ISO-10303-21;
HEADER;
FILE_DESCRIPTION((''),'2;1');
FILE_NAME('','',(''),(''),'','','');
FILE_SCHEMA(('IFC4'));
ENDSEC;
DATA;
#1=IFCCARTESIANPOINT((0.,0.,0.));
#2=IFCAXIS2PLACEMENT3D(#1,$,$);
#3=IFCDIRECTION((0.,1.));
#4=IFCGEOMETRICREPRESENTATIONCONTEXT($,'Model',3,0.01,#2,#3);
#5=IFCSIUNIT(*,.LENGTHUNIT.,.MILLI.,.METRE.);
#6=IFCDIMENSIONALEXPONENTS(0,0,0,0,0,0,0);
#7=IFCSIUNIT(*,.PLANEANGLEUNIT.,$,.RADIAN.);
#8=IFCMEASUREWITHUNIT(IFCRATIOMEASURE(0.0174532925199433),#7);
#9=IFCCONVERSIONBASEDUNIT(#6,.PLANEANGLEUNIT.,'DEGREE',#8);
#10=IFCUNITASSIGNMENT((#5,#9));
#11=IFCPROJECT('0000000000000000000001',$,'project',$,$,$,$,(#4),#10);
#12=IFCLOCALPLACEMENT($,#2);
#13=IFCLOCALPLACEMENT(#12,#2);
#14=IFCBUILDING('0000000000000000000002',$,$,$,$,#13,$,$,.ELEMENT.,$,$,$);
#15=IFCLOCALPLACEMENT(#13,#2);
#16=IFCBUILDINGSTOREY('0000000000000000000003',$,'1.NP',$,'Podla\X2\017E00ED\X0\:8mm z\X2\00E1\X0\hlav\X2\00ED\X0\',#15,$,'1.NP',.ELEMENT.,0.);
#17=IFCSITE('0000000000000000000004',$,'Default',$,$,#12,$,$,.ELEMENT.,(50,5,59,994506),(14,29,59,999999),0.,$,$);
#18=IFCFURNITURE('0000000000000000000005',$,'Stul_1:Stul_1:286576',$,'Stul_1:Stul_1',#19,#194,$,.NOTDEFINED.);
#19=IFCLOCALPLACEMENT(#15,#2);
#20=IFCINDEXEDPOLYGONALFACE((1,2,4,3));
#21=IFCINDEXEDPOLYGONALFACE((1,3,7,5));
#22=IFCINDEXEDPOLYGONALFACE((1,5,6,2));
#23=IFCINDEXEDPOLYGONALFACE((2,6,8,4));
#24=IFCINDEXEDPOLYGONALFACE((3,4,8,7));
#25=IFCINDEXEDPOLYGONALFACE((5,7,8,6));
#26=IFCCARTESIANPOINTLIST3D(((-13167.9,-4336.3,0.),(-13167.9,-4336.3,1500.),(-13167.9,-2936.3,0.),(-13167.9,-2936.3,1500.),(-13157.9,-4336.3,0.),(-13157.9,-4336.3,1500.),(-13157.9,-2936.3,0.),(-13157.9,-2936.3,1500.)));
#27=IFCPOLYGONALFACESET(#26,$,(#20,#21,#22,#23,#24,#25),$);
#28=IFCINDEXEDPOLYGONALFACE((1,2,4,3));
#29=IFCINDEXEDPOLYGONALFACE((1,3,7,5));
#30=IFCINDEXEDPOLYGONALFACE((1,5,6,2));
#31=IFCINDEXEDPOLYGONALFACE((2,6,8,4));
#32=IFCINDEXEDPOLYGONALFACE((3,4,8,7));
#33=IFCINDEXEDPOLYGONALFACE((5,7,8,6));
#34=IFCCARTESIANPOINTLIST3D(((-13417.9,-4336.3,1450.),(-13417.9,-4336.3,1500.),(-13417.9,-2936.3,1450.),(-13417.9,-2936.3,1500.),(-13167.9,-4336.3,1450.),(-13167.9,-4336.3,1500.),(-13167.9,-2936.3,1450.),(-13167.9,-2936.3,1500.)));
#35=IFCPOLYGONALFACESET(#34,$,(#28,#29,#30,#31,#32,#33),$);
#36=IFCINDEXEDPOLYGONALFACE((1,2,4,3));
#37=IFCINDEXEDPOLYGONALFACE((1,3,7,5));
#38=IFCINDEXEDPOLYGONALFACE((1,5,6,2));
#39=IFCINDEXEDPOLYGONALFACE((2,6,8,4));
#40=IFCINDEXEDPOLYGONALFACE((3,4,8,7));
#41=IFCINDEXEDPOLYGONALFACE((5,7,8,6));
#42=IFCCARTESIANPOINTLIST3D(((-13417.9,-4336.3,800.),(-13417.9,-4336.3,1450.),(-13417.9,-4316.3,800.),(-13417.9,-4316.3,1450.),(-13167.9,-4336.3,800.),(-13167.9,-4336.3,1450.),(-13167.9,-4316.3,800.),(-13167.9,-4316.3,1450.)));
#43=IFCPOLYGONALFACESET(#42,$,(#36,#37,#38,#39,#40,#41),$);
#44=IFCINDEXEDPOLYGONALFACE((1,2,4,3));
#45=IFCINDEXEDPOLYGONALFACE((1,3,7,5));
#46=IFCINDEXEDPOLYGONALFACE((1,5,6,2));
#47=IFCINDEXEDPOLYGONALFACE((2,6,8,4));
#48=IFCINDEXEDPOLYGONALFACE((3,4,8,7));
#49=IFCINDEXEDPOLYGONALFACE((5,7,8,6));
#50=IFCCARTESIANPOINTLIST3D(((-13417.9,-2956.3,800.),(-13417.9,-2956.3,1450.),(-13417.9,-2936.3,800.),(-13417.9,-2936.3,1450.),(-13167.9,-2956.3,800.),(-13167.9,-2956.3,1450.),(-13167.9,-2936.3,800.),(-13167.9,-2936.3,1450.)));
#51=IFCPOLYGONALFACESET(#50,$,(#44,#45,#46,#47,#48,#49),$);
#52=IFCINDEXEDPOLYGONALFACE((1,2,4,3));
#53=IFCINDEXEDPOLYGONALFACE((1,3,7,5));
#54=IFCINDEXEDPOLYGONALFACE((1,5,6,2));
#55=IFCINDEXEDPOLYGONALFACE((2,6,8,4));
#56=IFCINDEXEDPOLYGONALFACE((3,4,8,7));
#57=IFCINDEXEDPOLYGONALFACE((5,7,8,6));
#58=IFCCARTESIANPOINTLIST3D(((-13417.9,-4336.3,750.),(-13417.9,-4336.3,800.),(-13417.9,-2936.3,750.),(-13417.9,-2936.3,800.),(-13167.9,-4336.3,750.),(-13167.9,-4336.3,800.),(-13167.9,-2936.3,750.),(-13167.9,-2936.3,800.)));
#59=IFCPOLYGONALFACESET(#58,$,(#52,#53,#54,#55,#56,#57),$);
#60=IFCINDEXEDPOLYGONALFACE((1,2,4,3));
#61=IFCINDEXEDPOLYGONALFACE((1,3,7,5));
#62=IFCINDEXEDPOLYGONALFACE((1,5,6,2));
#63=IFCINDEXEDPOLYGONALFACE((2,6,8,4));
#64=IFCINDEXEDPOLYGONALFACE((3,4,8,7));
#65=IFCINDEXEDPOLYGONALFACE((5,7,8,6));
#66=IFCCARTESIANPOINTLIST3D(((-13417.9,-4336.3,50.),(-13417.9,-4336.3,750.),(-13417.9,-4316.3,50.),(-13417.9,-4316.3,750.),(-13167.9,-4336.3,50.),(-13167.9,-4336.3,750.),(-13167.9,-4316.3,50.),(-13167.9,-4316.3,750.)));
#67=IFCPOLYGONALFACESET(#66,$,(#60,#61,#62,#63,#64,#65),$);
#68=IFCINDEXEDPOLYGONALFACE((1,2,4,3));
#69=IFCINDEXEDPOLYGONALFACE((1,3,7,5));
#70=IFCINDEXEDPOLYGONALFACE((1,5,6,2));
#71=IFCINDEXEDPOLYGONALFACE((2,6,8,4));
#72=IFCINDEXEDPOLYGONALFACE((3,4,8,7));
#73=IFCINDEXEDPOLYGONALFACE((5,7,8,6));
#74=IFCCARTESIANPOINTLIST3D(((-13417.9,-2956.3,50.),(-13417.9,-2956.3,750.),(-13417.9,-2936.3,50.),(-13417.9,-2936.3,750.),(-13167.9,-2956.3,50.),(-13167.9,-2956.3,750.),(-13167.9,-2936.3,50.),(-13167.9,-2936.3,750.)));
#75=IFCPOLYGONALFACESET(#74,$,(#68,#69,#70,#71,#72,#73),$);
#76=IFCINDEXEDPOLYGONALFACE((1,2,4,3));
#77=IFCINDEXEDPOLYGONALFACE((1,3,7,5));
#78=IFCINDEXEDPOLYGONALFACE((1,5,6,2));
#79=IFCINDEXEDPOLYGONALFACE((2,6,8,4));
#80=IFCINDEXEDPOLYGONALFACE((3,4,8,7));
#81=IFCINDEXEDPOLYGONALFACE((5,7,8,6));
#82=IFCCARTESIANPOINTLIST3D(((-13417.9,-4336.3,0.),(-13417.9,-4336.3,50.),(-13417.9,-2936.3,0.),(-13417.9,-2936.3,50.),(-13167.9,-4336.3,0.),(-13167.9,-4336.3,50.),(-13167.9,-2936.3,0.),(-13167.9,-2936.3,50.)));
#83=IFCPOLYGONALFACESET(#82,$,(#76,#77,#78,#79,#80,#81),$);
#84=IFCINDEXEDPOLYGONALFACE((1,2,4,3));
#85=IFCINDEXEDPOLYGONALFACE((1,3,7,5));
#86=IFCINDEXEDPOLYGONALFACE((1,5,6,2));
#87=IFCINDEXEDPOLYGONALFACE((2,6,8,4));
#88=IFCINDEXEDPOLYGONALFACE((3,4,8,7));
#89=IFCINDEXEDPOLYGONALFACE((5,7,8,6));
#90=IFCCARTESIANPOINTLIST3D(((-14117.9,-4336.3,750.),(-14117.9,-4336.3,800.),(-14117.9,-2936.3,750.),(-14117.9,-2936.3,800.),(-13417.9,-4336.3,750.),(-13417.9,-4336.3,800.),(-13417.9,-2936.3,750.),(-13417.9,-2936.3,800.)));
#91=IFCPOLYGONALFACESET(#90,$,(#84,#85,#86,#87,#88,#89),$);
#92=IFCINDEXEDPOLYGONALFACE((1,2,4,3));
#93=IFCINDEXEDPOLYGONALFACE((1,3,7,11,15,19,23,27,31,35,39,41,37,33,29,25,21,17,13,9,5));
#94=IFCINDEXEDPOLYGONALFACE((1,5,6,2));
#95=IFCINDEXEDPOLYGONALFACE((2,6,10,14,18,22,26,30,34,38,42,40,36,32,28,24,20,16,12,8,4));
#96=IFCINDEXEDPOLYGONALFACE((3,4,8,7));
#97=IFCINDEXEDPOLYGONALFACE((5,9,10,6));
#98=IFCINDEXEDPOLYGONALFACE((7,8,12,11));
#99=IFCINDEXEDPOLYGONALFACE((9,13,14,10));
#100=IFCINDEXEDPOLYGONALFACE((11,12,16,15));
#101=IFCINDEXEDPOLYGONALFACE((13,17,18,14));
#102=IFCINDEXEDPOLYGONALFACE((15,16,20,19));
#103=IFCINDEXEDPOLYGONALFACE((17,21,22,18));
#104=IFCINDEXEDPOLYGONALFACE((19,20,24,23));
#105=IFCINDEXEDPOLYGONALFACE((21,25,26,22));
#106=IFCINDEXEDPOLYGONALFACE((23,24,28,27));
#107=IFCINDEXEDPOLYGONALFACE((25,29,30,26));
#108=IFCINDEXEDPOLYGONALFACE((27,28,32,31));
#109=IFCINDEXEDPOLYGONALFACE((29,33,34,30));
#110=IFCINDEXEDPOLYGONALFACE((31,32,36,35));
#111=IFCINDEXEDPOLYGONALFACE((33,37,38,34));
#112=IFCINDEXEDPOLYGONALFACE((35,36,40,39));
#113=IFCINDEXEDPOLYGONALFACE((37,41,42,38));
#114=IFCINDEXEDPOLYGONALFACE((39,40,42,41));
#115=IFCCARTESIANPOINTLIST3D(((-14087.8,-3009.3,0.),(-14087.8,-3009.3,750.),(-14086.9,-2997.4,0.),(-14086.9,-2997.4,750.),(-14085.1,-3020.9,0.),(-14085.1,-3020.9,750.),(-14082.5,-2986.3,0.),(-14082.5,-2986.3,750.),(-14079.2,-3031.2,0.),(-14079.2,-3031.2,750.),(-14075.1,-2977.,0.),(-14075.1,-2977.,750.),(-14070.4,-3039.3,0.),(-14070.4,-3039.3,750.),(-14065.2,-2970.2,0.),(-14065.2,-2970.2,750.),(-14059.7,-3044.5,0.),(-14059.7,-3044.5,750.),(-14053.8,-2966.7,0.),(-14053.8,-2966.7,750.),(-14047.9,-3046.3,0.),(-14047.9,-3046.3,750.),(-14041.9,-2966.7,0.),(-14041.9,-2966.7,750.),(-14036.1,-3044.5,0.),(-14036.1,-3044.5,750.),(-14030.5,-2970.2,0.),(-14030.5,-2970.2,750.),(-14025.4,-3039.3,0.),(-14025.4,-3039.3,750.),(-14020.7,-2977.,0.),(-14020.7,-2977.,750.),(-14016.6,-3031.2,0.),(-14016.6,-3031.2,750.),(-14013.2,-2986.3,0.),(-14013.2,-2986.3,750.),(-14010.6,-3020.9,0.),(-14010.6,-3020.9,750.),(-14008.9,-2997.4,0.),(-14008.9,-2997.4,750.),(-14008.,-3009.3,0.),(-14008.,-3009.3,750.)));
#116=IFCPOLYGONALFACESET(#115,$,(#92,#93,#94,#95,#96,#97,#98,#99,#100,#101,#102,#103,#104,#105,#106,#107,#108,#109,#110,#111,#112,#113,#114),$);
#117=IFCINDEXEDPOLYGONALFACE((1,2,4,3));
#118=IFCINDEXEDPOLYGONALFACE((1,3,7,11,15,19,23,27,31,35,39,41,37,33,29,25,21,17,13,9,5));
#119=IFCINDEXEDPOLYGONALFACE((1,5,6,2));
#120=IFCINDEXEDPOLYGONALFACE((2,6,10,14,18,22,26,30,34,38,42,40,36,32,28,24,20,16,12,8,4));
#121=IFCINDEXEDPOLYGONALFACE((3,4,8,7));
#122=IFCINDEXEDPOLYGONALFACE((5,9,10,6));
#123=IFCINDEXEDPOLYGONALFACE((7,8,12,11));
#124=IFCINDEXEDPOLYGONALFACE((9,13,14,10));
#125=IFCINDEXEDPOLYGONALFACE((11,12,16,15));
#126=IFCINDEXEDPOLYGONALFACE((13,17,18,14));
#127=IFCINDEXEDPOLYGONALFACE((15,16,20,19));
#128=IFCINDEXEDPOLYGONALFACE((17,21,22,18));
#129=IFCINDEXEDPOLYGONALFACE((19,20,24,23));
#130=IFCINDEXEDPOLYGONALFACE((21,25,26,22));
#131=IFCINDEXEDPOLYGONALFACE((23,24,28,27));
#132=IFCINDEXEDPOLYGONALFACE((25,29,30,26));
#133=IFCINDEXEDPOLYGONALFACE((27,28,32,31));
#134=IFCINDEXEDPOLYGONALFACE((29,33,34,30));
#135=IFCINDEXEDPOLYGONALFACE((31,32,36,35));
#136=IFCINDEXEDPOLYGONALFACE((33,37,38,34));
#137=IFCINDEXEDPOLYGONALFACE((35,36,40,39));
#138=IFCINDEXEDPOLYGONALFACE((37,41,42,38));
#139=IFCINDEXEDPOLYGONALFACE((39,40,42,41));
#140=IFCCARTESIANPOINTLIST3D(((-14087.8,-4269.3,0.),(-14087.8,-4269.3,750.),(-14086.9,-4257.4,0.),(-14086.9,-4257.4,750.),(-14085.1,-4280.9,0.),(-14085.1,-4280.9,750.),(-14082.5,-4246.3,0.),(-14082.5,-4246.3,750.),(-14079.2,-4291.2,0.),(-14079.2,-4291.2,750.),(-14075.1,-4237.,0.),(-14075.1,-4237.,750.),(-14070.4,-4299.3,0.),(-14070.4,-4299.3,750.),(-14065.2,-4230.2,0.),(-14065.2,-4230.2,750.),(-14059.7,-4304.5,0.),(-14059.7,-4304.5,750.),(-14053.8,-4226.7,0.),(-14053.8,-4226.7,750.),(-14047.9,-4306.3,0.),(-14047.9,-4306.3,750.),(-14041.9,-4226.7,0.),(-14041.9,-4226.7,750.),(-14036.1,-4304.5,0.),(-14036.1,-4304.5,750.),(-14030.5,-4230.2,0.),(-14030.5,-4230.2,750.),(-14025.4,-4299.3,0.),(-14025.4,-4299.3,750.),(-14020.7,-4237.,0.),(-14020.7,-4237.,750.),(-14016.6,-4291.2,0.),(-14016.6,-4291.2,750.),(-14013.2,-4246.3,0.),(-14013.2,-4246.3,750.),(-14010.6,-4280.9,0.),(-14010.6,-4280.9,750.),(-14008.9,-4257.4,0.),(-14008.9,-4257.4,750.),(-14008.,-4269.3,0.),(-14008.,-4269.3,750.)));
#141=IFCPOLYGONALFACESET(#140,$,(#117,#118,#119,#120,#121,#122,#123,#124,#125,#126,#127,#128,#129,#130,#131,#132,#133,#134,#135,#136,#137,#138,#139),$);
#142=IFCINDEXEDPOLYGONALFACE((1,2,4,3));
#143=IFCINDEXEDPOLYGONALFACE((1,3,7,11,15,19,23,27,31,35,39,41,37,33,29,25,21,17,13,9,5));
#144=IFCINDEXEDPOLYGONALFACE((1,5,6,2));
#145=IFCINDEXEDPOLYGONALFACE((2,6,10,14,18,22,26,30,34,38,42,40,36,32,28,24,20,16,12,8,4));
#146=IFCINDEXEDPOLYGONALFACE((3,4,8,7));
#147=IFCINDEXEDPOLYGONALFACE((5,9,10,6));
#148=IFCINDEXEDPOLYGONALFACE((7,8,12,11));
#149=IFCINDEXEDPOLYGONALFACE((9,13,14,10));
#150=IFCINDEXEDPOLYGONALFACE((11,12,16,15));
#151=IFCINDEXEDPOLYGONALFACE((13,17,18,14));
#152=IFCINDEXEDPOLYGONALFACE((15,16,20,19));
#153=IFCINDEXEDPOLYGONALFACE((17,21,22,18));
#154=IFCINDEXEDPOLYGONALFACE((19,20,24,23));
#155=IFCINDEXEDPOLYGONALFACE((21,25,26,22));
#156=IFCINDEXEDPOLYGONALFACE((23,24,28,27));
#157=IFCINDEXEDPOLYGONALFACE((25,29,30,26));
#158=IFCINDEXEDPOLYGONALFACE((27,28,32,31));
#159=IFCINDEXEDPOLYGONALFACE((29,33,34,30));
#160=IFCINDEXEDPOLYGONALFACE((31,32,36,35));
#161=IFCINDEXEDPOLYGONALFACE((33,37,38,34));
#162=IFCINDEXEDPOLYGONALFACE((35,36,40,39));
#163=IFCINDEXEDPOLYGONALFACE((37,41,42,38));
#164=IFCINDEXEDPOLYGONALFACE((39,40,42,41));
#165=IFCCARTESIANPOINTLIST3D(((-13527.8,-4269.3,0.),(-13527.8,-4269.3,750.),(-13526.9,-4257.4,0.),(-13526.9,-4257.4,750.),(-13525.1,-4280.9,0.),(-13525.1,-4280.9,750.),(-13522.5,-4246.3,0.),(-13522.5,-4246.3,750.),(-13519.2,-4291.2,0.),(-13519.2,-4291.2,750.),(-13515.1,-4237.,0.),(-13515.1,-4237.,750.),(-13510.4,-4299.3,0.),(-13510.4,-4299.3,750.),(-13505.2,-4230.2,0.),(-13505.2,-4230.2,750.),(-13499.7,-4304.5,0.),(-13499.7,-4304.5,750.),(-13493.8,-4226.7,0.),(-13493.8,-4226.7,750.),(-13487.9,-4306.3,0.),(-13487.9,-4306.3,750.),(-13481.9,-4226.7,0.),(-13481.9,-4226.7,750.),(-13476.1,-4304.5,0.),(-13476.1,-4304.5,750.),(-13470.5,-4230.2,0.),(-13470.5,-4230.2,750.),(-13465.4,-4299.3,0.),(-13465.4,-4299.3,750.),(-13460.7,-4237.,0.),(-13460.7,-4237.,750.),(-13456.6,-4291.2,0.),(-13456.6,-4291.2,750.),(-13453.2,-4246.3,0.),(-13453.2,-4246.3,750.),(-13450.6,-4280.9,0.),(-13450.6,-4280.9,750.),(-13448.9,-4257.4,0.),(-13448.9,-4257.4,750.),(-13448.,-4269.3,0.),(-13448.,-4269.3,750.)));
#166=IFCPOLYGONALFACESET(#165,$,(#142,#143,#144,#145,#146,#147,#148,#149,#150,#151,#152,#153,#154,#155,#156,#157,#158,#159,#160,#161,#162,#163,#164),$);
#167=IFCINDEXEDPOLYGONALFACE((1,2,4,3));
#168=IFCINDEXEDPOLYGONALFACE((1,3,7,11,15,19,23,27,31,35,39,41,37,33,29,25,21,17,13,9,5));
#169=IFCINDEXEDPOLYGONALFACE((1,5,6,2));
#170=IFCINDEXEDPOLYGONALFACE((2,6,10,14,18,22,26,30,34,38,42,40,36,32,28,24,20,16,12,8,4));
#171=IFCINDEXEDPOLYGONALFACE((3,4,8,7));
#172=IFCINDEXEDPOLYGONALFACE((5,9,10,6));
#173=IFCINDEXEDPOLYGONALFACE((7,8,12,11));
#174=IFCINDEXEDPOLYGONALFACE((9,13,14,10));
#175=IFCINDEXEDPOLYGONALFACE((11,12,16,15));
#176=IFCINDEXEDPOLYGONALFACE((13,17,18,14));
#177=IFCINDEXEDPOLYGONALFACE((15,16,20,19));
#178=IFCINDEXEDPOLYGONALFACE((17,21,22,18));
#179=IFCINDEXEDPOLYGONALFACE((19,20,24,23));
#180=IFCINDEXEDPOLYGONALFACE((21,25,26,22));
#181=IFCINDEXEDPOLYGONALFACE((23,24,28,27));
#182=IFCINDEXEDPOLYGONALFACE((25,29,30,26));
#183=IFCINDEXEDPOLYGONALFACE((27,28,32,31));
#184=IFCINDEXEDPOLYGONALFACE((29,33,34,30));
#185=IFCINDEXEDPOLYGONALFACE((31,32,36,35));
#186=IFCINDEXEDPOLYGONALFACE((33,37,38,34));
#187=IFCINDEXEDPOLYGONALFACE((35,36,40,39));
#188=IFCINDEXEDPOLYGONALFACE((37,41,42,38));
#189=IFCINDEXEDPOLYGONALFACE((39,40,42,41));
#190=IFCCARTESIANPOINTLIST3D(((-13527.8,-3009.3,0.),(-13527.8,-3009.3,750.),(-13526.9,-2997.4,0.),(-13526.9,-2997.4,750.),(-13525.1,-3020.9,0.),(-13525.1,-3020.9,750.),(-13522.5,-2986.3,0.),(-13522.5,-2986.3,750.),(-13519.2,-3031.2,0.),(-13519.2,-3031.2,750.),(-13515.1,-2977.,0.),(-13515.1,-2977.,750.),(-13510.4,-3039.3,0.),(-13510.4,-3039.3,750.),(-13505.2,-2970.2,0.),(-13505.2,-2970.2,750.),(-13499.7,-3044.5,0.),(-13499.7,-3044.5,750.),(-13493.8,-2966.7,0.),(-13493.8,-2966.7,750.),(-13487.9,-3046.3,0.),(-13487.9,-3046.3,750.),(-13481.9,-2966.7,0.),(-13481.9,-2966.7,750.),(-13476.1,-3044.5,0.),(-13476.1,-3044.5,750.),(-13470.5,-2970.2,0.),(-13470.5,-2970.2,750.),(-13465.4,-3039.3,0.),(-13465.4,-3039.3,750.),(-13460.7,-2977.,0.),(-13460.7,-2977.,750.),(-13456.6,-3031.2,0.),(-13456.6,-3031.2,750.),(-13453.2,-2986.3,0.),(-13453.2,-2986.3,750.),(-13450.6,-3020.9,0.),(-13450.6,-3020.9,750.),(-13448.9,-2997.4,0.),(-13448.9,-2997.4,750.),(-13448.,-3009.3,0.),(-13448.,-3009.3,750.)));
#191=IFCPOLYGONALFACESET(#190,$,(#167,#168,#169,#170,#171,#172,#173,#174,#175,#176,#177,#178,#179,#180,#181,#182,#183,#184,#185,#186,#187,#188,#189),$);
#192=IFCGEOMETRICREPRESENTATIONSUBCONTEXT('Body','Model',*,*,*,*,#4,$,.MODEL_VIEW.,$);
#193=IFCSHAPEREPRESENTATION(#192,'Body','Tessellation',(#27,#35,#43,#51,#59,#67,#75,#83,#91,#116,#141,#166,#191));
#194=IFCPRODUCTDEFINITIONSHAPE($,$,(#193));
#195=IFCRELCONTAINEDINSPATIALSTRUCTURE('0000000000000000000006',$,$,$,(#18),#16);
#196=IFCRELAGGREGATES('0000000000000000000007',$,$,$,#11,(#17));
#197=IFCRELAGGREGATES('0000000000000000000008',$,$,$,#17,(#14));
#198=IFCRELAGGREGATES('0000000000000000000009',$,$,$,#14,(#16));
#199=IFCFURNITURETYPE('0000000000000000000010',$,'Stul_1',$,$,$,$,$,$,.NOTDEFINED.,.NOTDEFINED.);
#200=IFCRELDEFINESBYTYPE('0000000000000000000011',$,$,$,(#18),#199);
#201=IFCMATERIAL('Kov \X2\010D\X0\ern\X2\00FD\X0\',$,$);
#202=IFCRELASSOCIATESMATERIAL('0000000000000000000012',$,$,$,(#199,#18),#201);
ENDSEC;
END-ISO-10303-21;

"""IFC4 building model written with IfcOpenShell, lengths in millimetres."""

from ifc_helpers import new_model, entity, si_unit, converted_unit, direction, frame, frame_2d, origin, origin_2d_with_axis, place, context, subcontext, project, spatial, rectangle, circle, extrude, source, transform, mapped, material, type_object, type_shapes, element, save


model = new_model("IFC4")

# Units and contexts
model_context = context("Model", 3, precision=0.01, world=origin(), true_north=direction((0.0, 1.0)))
body_context = subcontext(model_context, "Body", "Model", "MODEL_VIEW")
ifc_project = project(units=[si_unit("LENGTHUNIT", "METRE", prefix="MILLI"), converted_unit("PLANEANGLEUNIT", "DEGREE", entity("IfcRatioMeasure", 0.0174532925199433), si_unit("PLANEANGLEUNIT", "RADIAN"), dimensions=[0, 0, 0, 0, 0, 0, 0])], contexts=[model_context])

# Site, building, storey
site_placement = place(None, origin())
site = spatial("IfcSite", under=ifc_project, at=site_placement, Name="Default", CompositionType="ELEMENT", RefLatitude=(50, 5, 59, 994506), RefLongitude=(14, 29, 59, 999999), RefElevation=0.0)
building_placement = place(site_placement, origin())
building = spatial("IfcBuilding", under=site, at=building_placement, CompositionType="ELEMENT")
storey_placement = place(building_placement, origin())
storey = spatial("IfcBuildingStorey", under=building, at=storey_placement, Name="1.NP", ObjectType="Podlaží:8mm záhlaví", LongName="1.NP", CompositionType="ELEMENT", Elevation=0.0)

# Furniture
ifc_material_1 = material(Name="Kov černý")
furniture_type = type_object("IfcFurnitureType", Name="Stul_1", AssemblyPlace="NOTDEFINED", PredefinedType="NOTDEFINED", material=ifc_material_1)
shared_shape_1 = source(origin(), body_context, "Body", "SweptSolid", [
    extrude(rectangle(XDim=1400.0, YDim=10.0, at=origin_2d_with_axis()), frame((0.0, 605.0, 0.0), z_axis=(0.0, 0.0, 1.0), x_axis=(-1.0, 0.0, 0.0)), (0.0, 0.0, 1.0), 1500.0),
    extrude(rectangle(XDim=1400.0, YDim=250.0, at=frame_2d((0.0, 0.0), x_axis=(1.0, 0.0))), frame((0.0, 475.0, 1450.0), z_axis=(0.0, 0.0, 1.0), x_axis=(-1.0, 0.0, 0.0)), (0.0, 0.0, 1.0), 50.0),
    extrude(rectangle(XDim=20.0, YDim=250.0, at=origin_2d_with_axis()), frame((690.0, 475.0, 800.0), z_axis=(0.0, 0.0, 1.0), x_axis=(-1.0, 0.0, 0.0)), (0.0, 0.0, 1.0), 650.0),
    extrude(rectangle(XDim=20.0, YDim=250.0, at=frame_2d((0.0, 0.0), x_axis=(1.0, 0.0))), frame((-690.0, 475.0, 800.0), z_axis=(0.0, 0.0, 1.0), x_axis=(-1.0, 0.0, 0.0)), (0.0, 0.0, 1.0), 650.0),
    extrude(rectangle(XDim=1400.0, YDim=250.0, at=origin_2d_with_axis()), frame((0.0, 475.0, 750.0), z_axis=(0.0, 0.0, 1.0), x_axis=(-1.0, 0.0, 0.0)), (0.0, 0.0, 1.0), 50.0),
    extrude(rectangle(XDim=20.0, YDim=250.0, at=origin_2d_with_axis()), frame((690.0, 475.0, 50.0), z_axis=(0.0, 0.0, 1.0), x_axis=(-1.0, 0.0, 0.0)), (0.0, 0.0, 1.0), 700.0),
    extrude(rectangle(XDim=20.0, YDim=250.0, at=frame_2d((0.0, 0.0), x_axis=(1.0, 0.0))), frame((-690.0, 475.0, 50.0), z_axis=(0.0, 0.0, 1.0), x_axis=(-1.0, 0.0, 0.0)), (0.0, 0.0, 1.0), 700.0),
    extrude(rectangle(XDim=1400.0, YDim=250.0, at=origin_2d_with_axis()), frame((0.0, 475.0, 0.0), z_axis=(0.0, 0.0, 1.0), x_axis=(-1.0, 0.0, 0.0)), (0.0, 0.0, 1.0), 50.0),
    extrude(rectangle(XDim=1400.0, YDim=700.0, at=origin_2d_with_axis()), frame((0.0, 0.0, 750.0), z_axis=(0.0, 0.0, 1.0), x_axis=(-1.0, 0.0, 0.0)), (0.0, 0.0, 1.0), 50.0),
    extrude(circle(Radius=40.0, at=frame_2d((0.0, 0.0), x_axis=(1.0, 0.0))), frame((-630.0, -280.0, 0.0)), (0.0, 0.0, 1.0), 750.0),
    extrude(circle(Radius=40.0, at=frame_2d((0.0, 0.0), x_axis=(1.0, 0.0))), frame((630.0, -280.0, 0.0)), (0.0, 0.0, 1.0), 750.0),
    extrude(circle(Radius=40.0, at=frame_2d((0.0, 0.0), x_axis=(1.0, 0.0))), frame((630.0, 280.0, 0.0)), (0.0, 0.0, 1.0), 750.0),
    extrude(circle(Radius=40.0, at=frame_2d((0.0, 0.0), x_axis=(1.0, 0.0))), frame((-630.0, 280.0, 0.0)), (0.0, 0.0, 1.0), 750.0),
])
type_shapes(furniture_type, [shared_shape_1])
for number, where, z_axis, x_axis, name in (
    (1, (-13767.9, -3636.3, 0.0), (0.0, 0.0, 1.0), (0.0, -1.0, 0.0), "Stul_1:Stul_1:286576"),
):
    element("IfcFurniture", number, at=place(storey_placement, frame(where, z_axis=z_axis, x_axis=x_axis)), inside=storey, type_object=furniture_type, material=ifc_material_1, Name=name, ObjectType="Stul_1:Stul_1", PredefinedType="NOTDEFINED", context=body_context, shape_type="MappedRepresentation", body=[
        mapped(shared_shape_1, transform((0.0, 0.0, 0.0), scale=1.0)),
    ])

save(model, "model.ifc")
